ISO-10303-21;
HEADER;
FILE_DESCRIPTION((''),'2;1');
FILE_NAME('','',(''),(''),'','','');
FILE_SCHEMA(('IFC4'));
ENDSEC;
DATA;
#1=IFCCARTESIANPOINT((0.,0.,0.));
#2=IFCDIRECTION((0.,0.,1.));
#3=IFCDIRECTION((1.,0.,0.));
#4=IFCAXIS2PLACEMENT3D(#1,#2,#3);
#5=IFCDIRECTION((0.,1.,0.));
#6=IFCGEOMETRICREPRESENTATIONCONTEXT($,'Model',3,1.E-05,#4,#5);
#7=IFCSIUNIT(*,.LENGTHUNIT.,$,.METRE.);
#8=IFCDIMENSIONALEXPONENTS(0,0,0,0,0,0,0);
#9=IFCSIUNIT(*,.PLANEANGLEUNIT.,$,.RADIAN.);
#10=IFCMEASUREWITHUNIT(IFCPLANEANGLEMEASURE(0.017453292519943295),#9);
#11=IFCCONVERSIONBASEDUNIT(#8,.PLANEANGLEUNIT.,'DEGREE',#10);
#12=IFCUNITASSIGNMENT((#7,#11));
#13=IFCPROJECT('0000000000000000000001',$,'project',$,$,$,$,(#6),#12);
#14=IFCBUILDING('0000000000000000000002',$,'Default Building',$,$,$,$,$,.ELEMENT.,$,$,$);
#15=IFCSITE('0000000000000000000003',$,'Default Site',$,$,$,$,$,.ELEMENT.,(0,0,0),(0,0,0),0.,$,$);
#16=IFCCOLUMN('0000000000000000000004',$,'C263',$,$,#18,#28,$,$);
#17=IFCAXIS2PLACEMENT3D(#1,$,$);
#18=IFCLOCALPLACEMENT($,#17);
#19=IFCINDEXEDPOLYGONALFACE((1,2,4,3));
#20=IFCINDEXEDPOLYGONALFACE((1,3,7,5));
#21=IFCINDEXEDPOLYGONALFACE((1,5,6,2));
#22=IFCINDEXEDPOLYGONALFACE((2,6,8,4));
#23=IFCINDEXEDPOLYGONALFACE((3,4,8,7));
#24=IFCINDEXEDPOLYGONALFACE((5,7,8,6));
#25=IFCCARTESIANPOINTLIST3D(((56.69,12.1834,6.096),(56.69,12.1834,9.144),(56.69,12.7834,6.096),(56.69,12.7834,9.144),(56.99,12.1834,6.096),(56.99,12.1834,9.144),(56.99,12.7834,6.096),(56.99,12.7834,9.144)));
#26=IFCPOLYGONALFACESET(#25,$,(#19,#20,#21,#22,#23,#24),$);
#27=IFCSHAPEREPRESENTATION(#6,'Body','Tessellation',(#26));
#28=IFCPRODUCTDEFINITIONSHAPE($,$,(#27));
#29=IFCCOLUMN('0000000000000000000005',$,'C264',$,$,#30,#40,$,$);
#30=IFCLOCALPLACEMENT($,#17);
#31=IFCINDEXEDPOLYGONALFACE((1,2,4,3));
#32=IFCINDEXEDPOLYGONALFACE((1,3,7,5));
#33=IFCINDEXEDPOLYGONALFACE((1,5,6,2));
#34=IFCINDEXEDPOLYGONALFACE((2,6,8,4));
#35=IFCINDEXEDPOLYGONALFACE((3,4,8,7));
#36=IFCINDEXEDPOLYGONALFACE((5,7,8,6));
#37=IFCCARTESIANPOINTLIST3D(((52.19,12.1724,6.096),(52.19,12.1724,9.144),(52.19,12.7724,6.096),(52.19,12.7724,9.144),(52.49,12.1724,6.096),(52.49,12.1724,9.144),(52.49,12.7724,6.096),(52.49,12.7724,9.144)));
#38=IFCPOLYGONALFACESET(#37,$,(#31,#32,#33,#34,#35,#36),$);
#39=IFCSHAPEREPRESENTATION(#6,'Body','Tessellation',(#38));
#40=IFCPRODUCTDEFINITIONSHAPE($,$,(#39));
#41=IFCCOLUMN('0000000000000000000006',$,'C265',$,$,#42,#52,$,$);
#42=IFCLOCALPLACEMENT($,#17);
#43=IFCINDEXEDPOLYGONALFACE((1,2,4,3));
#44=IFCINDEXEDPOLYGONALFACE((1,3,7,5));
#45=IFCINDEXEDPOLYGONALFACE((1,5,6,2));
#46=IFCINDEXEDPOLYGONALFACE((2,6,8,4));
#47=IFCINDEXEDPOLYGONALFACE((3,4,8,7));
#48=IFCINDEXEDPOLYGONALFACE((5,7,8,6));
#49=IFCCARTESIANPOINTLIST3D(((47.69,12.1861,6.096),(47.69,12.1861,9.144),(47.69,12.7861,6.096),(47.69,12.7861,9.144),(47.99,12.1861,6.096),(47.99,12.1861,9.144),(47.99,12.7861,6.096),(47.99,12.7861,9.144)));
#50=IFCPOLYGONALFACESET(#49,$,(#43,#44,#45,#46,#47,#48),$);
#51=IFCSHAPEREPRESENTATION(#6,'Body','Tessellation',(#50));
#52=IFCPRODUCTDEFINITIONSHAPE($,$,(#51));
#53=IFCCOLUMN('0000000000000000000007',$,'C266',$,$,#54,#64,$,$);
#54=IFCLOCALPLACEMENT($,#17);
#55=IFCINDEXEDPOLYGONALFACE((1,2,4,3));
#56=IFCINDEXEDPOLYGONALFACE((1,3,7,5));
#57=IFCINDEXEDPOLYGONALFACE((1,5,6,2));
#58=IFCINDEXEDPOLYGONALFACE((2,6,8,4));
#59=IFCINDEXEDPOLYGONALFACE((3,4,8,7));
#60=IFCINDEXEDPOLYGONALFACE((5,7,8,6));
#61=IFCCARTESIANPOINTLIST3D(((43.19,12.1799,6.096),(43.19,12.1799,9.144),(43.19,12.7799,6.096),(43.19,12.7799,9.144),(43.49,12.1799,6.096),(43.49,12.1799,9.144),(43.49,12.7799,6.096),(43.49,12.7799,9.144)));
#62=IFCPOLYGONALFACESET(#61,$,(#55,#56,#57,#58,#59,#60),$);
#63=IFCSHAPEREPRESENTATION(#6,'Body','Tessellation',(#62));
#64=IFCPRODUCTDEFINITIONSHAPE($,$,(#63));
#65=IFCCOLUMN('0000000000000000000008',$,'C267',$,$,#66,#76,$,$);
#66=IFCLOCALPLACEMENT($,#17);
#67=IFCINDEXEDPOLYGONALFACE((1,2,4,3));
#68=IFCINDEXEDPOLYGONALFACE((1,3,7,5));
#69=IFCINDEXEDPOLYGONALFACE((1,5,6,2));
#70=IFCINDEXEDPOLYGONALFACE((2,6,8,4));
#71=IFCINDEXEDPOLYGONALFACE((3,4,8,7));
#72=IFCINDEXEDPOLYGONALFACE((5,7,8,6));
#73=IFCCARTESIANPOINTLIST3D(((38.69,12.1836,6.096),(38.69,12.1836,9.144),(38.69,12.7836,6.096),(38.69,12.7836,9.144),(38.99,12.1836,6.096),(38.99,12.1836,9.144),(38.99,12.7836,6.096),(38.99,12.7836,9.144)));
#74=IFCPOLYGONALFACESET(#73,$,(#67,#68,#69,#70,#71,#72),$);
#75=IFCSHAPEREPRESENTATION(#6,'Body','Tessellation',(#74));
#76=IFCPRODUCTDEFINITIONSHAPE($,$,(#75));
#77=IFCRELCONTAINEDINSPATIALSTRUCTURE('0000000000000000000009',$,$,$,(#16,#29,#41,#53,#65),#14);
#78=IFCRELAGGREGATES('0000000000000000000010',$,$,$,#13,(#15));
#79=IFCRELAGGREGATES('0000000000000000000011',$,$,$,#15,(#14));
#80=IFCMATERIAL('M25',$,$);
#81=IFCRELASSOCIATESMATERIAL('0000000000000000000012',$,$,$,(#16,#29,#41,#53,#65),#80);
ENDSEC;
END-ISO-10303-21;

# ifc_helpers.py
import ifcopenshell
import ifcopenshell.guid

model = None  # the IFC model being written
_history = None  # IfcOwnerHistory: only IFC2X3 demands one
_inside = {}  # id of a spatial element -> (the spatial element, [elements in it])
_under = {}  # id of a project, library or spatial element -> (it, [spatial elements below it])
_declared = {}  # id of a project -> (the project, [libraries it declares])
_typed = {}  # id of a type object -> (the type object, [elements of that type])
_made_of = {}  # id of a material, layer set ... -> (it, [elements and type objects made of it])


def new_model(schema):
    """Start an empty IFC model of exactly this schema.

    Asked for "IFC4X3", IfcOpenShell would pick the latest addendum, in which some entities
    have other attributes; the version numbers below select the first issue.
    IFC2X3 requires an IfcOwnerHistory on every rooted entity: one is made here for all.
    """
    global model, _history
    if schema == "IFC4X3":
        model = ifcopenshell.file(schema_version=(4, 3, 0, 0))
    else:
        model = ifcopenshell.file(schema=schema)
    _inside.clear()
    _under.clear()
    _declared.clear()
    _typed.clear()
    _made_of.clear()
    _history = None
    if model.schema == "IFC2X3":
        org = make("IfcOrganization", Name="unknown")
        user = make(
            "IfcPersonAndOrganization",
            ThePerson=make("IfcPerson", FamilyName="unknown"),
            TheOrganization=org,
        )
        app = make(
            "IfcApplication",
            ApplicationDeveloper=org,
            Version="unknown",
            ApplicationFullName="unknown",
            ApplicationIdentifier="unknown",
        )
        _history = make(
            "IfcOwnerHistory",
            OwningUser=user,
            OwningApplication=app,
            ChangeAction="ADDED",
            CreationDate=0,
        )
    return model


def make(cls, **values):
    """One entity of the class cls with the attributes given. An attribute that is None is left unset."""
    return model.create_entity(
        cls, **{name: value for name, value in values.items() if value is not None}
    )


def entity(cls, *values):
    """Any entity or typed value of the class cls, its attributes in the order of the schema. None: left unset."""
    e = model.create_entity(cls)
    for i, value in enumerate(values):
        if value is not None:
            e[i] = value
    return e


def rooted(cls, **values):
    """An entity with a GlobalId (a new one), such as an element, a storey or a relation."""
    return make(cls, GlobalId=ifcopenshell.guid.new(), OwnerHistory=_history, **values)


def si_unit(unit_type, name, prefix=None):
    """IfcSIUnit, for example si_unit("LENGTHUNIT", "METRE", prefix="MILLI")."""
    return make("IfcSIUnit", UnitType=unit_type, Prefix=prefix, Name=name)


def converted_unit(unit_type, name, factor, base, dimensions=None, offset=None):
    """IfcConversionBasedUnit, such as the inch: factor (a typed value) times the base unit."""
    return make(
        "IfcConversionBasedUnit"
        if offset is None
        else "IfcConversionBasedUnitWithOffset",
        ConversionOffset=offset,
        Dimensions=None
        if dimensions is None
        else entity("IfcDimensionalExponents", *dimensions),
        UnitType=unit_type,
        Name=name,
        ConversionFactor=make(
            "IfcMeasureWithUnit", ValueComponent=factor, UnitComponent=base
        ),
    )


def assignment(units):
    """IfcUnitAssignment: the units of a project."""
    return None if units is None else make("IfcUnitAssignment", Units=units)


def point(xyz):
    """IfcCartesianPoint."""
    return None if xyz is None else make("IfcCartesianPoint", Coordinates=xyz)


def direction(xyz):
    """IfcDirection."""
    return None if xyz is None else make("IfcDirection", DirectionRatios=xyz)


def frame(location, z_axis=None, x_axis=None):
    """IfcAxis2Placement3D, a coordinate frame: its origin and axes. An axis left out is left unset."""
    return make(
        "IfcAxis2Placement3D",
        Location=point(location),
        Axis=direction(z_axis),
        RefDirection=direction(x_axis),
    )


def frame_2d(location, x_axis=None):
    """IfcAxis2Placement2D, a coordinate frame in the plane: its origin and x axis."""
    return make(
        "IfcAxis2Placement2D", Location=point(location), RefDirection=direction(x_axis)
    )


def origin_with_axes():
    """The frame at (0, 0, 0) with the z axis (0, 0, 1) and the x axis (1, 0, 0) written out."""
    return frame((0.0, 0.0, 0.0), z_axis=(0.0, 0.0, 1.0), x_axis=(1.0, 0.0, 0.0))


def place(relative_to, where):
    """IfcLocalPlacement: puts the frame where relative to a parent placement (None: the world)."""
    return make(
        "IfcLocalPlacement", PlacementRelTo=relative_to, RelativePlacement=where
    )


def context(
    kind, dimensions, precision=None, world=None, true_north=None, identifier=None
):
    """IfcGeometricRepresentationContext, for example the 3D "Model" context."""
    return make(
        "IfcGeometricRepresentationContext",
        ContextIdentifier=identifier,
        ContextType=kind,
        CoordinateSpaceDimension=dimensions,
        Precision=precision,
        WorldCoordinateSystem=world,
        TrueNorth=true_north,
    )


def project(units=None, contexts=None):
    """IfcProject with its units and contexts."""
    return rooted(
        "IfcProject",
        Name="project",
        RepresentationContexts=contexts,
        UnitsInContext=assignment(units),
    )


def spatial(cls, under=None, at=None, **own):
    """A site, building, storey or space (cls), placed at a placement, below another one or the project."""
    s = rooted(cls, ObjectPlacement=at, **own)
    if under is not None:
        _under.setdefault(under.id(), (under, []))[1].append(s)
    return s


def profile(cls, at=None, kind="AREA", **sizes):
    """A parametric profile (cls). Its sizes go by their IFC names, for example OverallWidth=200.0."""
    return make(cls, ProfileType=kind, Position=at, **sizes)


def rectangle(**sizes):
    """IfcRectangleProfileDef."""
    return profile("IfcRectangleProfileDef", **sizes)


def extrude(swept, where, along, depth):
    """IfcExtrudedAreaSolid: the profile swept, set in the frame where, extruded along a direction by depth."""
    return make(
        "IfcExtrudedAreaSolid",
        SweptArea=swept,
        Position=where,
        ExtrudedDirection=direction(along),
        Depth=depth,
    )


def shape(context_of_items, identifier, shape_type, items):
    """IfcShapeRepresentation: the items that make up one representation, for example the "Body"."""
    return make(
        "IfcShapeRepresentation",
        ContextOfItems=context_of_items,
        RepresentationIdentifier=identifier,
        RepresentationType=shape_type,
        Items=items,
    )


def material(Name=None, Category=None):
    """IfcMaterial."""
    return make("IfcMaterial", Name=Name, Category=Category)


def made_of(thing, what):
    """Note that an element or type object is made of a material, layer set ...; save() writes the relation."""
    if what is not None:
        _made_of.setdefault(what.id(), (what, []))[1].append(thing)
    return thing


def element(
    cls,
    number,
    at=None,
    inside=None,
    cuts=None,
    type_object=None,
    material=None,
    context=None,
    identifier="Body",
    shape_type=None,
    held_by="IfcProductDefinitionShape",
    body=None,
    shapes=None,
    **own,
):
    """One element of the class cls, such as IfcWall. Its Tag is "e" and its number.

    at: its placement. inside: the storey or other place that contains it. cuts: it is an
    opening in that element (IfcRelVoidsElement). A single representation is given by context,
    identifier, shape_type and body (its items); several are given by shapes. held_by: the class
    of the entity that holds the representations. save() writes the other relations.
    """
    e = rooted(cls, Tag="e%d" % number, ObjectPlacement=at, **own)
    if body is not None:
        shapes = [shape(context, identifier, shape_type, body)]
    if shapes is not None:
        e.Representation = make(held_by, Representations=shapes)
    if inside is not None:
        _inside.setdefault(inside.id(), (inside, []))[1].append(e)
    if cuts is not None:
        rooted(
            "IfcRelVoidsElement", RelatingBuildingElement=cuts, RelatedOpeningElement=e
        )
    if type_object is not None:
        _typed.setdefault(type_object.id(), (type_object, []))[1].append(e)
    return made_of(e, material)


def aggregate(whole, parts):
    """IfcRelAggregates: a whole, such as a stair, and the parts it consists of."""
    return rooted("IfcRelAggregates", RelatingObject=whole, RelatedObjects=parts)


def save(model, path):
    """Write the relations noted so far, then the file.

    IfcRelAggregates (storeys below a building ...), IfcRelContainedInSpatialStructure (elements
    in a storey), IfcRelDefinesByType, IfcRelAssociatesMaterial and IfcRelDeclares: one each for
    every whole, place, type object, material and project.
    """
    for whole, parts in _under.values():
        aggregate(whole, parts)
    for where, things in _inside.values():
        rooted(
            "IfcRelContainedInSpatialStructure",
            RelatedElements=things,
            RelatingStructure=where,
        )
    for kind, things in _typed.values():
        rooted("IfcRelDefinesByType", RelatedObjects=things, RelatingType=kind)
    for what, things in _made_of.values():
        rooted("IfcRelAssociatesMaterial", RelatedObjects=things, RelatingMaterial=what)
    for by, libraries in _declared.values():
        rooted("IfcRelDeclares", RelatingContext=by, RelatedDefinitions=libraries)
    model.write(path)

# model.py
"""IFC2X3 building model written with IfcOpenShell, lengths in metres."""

from ifc_helpers import new_model, entity, si_unit, converted_unit, direction, frame, frame_2d, origin_with_axes, place, context, project, spatial, rectangle, extrude, material, element, save


model = new_model("IFC2X3")

# Units and contexts
model_context = context("Model", 3, precision=1e-05, world=origin_with_axes(), true_north=direction((0.0, 1.0, 0.0)))
ifc_project = project(units=[si_unit("LENGTHUNIT", "METRE"), converted_unit("PLANEANGLEUNIT", "DEGREE", entity("IfcPlaneAngleMeasure", 0.017453292519943295), si_unit("PLANEANGLEUNIT", "RADIAN"), dimensions=[0, 0, 0, 0, 0, 0, 0])], contexts=[model_context])

# Site, building
site = spatial("IfcSite", under=ifc_project, Name="Default Site", CompositionType="ELEMENT", RefLatitude=(0, 0, 0), RefLongitude=(0, 0, 0), RefElevation=0.0)
building = spatial("IfcBuilding", under=site, Name="Default Building", CompositionType="ELEMENT")

# Columns
ifc_material = material(Name="M25")
placement = place(None, origin_with_axes())
element("IfcColumn", 1, at=placement, inside=building, material=ifc_material, Name="C263", context=model_context, shape_type="SweptSolid", body=[
    extrude(rectangle(XDim=0.3, YDim=0.6, at=frame_2d((0.0, 0.0), x_axis=(1.0, 0.0, 0.0))), frame((56.84, 12.4834, 6.096), z_axis=(0.0, 0.0, 1.0), x_axis=(1.0, 0.0, 0.0)), (0.0, 0.0, 1.0), 3.048),
])
element("IfcColumn", 2, at=placement, inside=building, material=ifc_material, Name="C264", context=model_context, shape_type="SweptSolid", body=[
    extrude(rectangle(XDim=0.3, YDim=0.6, at=frame_2d((0.0, 0.0), x_axis=(1.0, 0.0, 0.0))), frame((52.34, 12.4724, 6.096), z_axis=(0.0, 0.0, 1.0), x_axis=(1.0, 0.0, 0.0)), (0.0, 0.0, 1.0), 3.048),
])
element("IfcColumn", 3, at=placement, inside=building, material=ifc_material, Name="C265", context=model_context, shape_type="SweptSolid", body=[
    extrude(rectangle(XDim=0.3, YDim=0.6, at=frame_2d((0.0, 0.0), x_axis=(1.0, 0.0, 0.0))), frame((47.84, 12.4861, 6.096), z_axis=(0.0, 0.0, 1.0), x_axis=(1.0, 0.0, 0.0)), (0.0, 0.0, 1.0), 3.048),
])
element("IfcColumn", 4, at=placement, inside=building, material=ifc_material, Name="C266", context=model_context, shape_type="SweptSolid", body=[
    extrude(rectangle(XDim=0.3, YDim=0.6, at=frame_2d((0.0, 0.0), x_axis=(1.0, 0.0, 0.0))), frame((43.34, 12.4799, 6.096), z_axis=(0.0, 0.0, 1.0), x_axis=(1.0, 0.0, 0.0)), (0.0, 0.0, 1.0), 3.048),
])
element("IfcColumn", 5, at=placement, inside=building, material=ifc_material, Name="C267", context=model_context, shape_type="SweptSolid", body=[
    extrude(rectangle(XDim=0.3, YDim=0.6, at=frame_2d((0.0, 0.0), x_axis=(1.0, 0.0, 0.0))), frame((38.84, 12.4836, 6.096), z_axis=(0.0, 0.0, 1.0), x_axis=(1.0, 0.0, 0.0)), (0.0, 0.0, 1.0), 3.048),
])

save(model, "model.ifc")
